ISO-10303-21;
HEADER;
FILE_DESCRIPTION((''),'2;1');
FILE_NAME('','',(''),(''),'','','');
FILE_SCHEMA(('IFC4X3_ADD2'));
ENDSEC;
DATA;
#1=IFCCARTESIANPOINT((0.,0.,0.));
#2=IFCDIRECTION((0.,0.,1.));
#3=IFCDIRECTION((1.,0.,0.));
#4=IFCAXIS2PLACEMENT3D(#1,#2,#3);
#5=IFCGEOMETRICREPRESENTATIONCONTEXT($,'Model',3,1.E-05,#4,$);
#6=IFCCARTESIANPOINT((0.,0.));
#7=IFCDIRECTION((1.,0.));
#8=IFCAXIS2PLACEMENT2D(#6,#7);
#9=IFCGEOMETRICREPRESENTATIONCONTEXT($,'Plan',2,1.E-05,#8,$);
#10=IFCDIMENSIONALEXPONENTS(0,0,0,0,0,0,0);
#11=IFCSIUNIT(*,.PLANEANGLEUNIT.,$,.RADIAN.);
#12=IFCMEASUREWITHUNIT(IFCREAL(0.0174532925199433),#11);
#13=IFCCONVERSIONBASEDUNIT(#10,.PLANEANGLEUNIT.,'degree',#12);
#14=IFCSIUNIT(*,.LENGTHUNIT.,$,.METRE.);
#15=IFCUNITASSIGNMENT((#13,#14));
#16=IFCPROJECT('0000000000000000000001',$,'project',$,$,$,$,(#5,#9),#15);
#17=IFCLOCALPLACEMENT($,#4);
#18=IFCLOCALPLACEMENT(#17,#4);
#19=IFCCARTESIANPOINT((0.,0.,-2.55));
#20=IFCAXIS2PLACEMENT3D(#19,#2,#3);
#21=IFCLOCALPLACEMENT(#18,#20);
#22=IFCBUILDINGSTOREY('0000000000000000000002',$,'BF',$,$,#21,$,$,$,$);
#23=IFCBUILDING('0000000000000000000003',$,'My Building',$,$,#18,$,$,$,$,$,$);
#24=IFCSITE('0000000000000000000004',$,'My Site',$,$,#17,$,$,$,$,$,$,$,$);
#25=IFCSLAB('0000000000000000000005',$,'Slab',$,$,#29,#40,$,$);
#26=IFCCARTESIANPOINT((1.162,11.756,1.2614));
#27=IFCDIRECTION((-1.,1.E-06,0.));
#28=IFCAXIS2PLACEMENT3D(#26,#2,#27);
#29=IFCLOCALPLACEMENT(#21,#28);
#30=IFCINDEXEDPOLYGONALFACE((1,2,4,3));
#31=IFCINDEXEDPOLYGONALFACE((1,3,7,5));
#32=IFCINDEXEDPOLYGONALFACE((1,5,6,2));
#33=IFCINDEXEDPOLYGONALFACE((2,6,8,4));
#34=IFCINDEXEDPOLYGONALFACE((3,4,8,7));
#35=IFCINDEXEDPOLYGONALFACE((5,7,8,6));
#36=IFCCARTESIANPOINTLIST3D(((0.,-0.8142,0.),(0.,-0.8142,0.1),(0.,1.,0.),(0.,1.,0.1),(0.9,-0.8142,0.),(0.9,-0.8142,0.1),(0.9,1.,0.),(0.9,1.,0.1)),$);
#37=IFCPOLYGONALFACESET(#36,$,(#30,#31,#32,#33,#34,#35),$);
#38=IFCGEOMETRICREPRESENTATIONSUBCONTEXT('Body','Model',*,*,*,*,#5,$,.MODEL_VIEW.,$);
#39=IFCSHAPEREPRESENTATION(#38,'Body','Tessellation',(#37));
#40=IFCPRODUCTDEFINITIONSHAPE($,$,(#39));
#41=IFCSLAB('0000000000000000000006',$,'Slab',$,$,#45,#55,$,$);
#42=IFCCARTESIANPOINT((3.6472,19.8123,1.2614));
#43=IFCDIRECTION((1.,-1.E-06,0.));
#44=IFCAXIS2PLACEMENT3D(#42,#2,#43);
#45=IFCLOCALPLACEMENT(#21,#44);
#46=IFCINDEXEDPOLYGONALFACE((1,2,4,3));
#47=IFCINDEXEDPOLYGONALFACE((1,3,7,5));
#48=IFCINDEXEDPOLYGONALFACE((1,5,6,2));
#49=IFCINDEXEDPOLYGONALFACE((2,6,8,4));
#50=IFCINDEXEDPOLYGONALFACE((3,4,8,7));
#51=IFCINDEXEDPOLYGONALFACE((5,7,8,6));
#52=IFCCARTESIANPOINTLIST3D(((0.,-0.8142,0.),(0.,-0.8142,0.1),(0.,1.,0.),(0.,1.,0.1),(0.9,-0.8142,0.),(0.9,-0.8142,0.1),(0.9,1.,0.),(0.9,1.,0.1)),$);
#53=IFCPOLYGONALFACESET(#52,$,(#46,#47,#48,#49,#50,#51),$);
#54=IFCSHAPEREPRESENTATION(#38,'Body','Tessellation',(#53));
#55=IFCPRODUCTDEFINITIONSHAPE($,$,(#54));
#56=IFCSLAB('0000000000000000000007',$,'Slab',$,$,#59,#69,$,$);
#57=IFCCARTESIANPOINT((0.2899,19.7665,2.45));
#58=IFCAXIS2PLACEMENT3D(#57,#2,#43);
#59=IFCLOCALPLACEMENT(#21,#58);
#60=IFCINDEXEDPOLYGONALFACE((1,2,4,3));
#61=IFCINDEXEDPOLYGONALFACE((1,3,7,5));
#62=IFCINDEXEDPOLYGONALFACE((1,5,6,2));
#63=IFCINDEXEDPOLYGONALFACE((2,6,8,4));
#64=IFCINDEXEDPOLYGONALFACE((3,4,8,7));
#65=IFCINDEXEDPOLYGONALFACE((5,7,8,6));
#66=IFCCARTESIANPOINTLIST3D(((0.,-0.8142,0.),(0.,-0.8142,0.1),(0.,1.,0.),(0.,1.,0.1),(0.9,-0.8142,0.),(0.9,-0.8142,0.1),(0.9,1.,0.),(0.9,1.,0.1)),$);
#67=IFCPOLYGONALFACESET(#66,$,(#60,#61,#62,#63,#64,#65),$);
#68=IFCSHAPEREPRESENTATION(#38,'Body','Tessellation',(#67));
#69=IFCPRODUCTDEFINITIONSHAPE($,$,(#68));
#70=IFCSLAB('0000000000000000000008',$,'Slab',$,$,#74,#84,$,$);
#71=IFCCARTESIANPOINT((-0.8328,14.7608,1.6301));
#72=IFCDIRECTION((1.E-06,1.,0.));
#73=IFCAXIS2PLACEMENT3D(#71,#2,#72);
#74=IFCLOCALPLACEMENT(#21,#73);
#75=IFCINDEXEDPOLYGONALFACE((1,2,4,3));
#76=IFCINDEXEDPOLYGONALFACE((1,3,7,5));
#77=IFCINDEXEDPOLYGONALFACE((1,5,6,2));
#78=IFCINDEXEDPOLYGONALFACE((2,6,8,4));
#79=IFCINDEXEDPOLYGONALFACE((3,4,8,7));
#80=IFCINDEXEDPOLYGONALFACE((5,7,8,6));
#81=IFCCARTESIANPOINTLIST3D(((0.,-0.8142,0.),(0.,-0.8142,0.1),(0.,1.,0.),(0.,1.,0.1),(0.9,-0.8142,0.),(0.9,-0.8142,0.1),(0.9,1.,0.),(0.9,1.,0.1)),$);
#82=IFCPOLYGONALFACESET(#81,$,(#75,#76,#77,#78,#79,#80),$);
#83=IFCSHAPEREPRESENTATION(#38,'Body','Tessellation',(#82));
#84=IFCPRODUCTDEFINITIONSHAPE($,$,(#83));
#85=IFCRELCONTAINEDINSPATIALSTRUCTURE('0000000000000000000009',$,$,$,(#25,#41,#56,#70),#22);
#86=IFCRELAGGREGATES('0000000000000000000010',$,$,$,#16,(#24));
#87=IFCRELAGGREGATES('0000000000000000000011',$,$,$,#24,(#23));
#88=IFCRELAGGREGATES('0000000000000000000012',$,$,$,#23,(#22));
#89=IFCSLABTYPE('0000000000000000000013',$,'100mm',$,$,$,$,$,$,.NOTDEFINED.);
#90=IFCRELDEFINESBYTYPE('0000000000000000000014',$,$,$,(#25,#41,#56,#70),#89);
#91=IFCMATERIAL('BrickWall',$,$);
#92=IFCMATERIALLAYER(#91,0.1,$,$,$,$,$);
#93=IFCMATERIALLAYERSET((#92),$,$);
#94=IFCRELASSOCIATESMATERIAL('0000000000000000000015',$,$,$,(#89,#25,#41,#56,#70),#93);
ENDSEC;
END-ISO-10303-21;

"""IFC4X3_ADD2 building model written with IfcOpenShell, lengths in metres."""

from ifc_helpers import new_model, entity, si_unit, converted_unit, frame, origin_with_axes, origin_2d_with_axis, place, context, subcontext, project, spatial, line, indexed_curve, outline, extrude, material, layer, layer_set, layer_usage, type_object, element, save


model = new_model("IFC4X3_ADD2")

# Units and contexts
model_context = context("Model", 3, precision=1e-05, world=origin_with_axes())
plan_context = context("Plan", 2, precision=1e-05, world=origin_2d_with_axis())
body_context_1 = subcontext(model_context, "Body", "Model", "MODEL_VIEW")
ifc_project = project(units=[converted_unit("PLANEANGLEUNIT", "degree", entity("IfcReal", 0.0174532925199433), si_unit("PLANEANGLEUNIT", "RADIAN"), dimensions=[0, 0, 0, 0, 0, 0, 0]), si_unit("LENGTHUNIT", "METRE")], contexts=[model_context, plan_context])

# Site, building, storey
site_placement = place(None, origin_with_axes())
site = spatial("IfcSite", under=ifc_project, at=site_placement, Name="My Site")
building_placement = place(site_placement, origin_with_axes())
building = spatial("IfcBuilding", under=site, at=building_placement, Name="My Building")
storey_placement = place(building_placement, frame((0.0, 0.0, -2.55), z_axis=(0.0, 0.0, 1.0), x_axis=(1.0, 0.0, 0.0)))
storey = spatial("IfcBuildingStorey", under=building, at=storey_placement, Name="BF")

# Slabs
ifc_material_1 = material(Name="BrickWall")
ifc_layer_1 = layer(ifc_material_1, 0.1)
ifc_layer_set_1 = layer_set([ifc_layer_1])
ifc_layer_usage_1 = layer_usage(ifc_layer_set_1, "AXIS3", "POSITIVE", 0.0)
slab_type_1 = type_object("IfcSlabType", Name="100mm", PredefinedType="NOTDEFINED", material=ifc_layer_set_1)
slab_1_placement = place(storey_placement, frame((1.162, 11.756, 1.2614), z_axis=(0.0, 0.0, 1.0), x_axis=(-1.0, 0.000001, 0.0)))
element("IfcSlab", 1, at=slab_1_placement, inside=storey, type_object=slab_type_1, material=ifc_layer_usage_1, Name="Slab", context=body_context_1, shape_type="SweptSolid", body=[
    extrude(outline(indexed_curve([(0.0, -0.8142), (0.0, 1.0), (0.9, 1.0), (0.9, -0.8142)], segments=[line(3, 2), line(2, 1), line(1, 4), line(4, 3)], self_intersect=False)), None, (0.0, 0.0, 1.0), 0.1),
])
ifc_layer_usage_2 = layer_usage(ifc_layer_set_1, "AXIS3", "POSITIVE", 0.0)
slab_2_placement = place(storey_placement, frame((3.6472, 19.8123, 1.2614), z_axis=(0.0, 0.0, 1.0), x_axis=(1.0, -0.000001, 0.0)))
element("IfcSlab", 2, at=slab_2_placement, inside=storey, type_object=slab_type_1, material=ifc_layer_usage_2, Name="Slab", context=body_context_1, shape_type="SweptSolid", body=[
    extrude(outline(indexed_curve([(0.0, -0.8142), (0.0, 1.0), (0.9, 1.0), (0.9, -0.8142)], segments=[line(3, 2), line(2, 1), line(1, 4), line(4, 3)], self_intersect=False)), None, (0.0, 0.0, 1.0), 0.1),
])
ifc_layer_usage_3 = layer_usage(ifc_layer_set_1, "AXIS3", "POSITIVE", 0.0)
slab_3_placement = place(storey_placement, frame((0.2899, 19.7665, 2.45), z_axis=(0.0, 0.0, 1.0), x_axis=(1.0, -0.000001, 0.0)))
element("IfcSlab", 3, at=slab_3_placement, inside=storey, type_object=slab_type_1, material=ifc_layer_usage_3, Name="Slab", context=body_context_1, shape_type="SweptSolid", body=[
    extrude(outline(indexed_curve([(0.0, -0.8142), (0.0, 1.0), (0.9, 1.0), (0.9, -0.8142)], segments=[line(3, 2), line(2, 1), line(1, 4), line(4, 3)], self_intersect=False)), None, (0.0, 0.0, 1.0), 0.1),
])
ifc_layer_usage_4 = layer_usage(ifc_layer_set_1, "AXIS3", "POSITIVE", 0.0)
slab_4_placement = place(storey_placement, frame((-0.8328, 14.7608, 1.6301), z_axis=(0.0, 0.0, 1.0), x_axis=(0.000001, 1.0, 0.0)))
element("IfcSlab", 4, at=slab_4_placement, inside=storey, type_object=slab_type_1, material=ifc_layer_usage_4, Name="Slab", context=body_context_1, shape_type="SweptSolid", body=[
    extrude(outline(indexed_curve([(0.0, -0.8142), (0.0, 1.0), (0.9, 1.0), (0.9, -0.8142)], segments=[line(3, 2), line(2, 1), line(1, 4), line(4, 3)], self_intersect=False)), None, (0.0, 0.0, 1.0), 0.1),
])

save(model, "model.ifc")
